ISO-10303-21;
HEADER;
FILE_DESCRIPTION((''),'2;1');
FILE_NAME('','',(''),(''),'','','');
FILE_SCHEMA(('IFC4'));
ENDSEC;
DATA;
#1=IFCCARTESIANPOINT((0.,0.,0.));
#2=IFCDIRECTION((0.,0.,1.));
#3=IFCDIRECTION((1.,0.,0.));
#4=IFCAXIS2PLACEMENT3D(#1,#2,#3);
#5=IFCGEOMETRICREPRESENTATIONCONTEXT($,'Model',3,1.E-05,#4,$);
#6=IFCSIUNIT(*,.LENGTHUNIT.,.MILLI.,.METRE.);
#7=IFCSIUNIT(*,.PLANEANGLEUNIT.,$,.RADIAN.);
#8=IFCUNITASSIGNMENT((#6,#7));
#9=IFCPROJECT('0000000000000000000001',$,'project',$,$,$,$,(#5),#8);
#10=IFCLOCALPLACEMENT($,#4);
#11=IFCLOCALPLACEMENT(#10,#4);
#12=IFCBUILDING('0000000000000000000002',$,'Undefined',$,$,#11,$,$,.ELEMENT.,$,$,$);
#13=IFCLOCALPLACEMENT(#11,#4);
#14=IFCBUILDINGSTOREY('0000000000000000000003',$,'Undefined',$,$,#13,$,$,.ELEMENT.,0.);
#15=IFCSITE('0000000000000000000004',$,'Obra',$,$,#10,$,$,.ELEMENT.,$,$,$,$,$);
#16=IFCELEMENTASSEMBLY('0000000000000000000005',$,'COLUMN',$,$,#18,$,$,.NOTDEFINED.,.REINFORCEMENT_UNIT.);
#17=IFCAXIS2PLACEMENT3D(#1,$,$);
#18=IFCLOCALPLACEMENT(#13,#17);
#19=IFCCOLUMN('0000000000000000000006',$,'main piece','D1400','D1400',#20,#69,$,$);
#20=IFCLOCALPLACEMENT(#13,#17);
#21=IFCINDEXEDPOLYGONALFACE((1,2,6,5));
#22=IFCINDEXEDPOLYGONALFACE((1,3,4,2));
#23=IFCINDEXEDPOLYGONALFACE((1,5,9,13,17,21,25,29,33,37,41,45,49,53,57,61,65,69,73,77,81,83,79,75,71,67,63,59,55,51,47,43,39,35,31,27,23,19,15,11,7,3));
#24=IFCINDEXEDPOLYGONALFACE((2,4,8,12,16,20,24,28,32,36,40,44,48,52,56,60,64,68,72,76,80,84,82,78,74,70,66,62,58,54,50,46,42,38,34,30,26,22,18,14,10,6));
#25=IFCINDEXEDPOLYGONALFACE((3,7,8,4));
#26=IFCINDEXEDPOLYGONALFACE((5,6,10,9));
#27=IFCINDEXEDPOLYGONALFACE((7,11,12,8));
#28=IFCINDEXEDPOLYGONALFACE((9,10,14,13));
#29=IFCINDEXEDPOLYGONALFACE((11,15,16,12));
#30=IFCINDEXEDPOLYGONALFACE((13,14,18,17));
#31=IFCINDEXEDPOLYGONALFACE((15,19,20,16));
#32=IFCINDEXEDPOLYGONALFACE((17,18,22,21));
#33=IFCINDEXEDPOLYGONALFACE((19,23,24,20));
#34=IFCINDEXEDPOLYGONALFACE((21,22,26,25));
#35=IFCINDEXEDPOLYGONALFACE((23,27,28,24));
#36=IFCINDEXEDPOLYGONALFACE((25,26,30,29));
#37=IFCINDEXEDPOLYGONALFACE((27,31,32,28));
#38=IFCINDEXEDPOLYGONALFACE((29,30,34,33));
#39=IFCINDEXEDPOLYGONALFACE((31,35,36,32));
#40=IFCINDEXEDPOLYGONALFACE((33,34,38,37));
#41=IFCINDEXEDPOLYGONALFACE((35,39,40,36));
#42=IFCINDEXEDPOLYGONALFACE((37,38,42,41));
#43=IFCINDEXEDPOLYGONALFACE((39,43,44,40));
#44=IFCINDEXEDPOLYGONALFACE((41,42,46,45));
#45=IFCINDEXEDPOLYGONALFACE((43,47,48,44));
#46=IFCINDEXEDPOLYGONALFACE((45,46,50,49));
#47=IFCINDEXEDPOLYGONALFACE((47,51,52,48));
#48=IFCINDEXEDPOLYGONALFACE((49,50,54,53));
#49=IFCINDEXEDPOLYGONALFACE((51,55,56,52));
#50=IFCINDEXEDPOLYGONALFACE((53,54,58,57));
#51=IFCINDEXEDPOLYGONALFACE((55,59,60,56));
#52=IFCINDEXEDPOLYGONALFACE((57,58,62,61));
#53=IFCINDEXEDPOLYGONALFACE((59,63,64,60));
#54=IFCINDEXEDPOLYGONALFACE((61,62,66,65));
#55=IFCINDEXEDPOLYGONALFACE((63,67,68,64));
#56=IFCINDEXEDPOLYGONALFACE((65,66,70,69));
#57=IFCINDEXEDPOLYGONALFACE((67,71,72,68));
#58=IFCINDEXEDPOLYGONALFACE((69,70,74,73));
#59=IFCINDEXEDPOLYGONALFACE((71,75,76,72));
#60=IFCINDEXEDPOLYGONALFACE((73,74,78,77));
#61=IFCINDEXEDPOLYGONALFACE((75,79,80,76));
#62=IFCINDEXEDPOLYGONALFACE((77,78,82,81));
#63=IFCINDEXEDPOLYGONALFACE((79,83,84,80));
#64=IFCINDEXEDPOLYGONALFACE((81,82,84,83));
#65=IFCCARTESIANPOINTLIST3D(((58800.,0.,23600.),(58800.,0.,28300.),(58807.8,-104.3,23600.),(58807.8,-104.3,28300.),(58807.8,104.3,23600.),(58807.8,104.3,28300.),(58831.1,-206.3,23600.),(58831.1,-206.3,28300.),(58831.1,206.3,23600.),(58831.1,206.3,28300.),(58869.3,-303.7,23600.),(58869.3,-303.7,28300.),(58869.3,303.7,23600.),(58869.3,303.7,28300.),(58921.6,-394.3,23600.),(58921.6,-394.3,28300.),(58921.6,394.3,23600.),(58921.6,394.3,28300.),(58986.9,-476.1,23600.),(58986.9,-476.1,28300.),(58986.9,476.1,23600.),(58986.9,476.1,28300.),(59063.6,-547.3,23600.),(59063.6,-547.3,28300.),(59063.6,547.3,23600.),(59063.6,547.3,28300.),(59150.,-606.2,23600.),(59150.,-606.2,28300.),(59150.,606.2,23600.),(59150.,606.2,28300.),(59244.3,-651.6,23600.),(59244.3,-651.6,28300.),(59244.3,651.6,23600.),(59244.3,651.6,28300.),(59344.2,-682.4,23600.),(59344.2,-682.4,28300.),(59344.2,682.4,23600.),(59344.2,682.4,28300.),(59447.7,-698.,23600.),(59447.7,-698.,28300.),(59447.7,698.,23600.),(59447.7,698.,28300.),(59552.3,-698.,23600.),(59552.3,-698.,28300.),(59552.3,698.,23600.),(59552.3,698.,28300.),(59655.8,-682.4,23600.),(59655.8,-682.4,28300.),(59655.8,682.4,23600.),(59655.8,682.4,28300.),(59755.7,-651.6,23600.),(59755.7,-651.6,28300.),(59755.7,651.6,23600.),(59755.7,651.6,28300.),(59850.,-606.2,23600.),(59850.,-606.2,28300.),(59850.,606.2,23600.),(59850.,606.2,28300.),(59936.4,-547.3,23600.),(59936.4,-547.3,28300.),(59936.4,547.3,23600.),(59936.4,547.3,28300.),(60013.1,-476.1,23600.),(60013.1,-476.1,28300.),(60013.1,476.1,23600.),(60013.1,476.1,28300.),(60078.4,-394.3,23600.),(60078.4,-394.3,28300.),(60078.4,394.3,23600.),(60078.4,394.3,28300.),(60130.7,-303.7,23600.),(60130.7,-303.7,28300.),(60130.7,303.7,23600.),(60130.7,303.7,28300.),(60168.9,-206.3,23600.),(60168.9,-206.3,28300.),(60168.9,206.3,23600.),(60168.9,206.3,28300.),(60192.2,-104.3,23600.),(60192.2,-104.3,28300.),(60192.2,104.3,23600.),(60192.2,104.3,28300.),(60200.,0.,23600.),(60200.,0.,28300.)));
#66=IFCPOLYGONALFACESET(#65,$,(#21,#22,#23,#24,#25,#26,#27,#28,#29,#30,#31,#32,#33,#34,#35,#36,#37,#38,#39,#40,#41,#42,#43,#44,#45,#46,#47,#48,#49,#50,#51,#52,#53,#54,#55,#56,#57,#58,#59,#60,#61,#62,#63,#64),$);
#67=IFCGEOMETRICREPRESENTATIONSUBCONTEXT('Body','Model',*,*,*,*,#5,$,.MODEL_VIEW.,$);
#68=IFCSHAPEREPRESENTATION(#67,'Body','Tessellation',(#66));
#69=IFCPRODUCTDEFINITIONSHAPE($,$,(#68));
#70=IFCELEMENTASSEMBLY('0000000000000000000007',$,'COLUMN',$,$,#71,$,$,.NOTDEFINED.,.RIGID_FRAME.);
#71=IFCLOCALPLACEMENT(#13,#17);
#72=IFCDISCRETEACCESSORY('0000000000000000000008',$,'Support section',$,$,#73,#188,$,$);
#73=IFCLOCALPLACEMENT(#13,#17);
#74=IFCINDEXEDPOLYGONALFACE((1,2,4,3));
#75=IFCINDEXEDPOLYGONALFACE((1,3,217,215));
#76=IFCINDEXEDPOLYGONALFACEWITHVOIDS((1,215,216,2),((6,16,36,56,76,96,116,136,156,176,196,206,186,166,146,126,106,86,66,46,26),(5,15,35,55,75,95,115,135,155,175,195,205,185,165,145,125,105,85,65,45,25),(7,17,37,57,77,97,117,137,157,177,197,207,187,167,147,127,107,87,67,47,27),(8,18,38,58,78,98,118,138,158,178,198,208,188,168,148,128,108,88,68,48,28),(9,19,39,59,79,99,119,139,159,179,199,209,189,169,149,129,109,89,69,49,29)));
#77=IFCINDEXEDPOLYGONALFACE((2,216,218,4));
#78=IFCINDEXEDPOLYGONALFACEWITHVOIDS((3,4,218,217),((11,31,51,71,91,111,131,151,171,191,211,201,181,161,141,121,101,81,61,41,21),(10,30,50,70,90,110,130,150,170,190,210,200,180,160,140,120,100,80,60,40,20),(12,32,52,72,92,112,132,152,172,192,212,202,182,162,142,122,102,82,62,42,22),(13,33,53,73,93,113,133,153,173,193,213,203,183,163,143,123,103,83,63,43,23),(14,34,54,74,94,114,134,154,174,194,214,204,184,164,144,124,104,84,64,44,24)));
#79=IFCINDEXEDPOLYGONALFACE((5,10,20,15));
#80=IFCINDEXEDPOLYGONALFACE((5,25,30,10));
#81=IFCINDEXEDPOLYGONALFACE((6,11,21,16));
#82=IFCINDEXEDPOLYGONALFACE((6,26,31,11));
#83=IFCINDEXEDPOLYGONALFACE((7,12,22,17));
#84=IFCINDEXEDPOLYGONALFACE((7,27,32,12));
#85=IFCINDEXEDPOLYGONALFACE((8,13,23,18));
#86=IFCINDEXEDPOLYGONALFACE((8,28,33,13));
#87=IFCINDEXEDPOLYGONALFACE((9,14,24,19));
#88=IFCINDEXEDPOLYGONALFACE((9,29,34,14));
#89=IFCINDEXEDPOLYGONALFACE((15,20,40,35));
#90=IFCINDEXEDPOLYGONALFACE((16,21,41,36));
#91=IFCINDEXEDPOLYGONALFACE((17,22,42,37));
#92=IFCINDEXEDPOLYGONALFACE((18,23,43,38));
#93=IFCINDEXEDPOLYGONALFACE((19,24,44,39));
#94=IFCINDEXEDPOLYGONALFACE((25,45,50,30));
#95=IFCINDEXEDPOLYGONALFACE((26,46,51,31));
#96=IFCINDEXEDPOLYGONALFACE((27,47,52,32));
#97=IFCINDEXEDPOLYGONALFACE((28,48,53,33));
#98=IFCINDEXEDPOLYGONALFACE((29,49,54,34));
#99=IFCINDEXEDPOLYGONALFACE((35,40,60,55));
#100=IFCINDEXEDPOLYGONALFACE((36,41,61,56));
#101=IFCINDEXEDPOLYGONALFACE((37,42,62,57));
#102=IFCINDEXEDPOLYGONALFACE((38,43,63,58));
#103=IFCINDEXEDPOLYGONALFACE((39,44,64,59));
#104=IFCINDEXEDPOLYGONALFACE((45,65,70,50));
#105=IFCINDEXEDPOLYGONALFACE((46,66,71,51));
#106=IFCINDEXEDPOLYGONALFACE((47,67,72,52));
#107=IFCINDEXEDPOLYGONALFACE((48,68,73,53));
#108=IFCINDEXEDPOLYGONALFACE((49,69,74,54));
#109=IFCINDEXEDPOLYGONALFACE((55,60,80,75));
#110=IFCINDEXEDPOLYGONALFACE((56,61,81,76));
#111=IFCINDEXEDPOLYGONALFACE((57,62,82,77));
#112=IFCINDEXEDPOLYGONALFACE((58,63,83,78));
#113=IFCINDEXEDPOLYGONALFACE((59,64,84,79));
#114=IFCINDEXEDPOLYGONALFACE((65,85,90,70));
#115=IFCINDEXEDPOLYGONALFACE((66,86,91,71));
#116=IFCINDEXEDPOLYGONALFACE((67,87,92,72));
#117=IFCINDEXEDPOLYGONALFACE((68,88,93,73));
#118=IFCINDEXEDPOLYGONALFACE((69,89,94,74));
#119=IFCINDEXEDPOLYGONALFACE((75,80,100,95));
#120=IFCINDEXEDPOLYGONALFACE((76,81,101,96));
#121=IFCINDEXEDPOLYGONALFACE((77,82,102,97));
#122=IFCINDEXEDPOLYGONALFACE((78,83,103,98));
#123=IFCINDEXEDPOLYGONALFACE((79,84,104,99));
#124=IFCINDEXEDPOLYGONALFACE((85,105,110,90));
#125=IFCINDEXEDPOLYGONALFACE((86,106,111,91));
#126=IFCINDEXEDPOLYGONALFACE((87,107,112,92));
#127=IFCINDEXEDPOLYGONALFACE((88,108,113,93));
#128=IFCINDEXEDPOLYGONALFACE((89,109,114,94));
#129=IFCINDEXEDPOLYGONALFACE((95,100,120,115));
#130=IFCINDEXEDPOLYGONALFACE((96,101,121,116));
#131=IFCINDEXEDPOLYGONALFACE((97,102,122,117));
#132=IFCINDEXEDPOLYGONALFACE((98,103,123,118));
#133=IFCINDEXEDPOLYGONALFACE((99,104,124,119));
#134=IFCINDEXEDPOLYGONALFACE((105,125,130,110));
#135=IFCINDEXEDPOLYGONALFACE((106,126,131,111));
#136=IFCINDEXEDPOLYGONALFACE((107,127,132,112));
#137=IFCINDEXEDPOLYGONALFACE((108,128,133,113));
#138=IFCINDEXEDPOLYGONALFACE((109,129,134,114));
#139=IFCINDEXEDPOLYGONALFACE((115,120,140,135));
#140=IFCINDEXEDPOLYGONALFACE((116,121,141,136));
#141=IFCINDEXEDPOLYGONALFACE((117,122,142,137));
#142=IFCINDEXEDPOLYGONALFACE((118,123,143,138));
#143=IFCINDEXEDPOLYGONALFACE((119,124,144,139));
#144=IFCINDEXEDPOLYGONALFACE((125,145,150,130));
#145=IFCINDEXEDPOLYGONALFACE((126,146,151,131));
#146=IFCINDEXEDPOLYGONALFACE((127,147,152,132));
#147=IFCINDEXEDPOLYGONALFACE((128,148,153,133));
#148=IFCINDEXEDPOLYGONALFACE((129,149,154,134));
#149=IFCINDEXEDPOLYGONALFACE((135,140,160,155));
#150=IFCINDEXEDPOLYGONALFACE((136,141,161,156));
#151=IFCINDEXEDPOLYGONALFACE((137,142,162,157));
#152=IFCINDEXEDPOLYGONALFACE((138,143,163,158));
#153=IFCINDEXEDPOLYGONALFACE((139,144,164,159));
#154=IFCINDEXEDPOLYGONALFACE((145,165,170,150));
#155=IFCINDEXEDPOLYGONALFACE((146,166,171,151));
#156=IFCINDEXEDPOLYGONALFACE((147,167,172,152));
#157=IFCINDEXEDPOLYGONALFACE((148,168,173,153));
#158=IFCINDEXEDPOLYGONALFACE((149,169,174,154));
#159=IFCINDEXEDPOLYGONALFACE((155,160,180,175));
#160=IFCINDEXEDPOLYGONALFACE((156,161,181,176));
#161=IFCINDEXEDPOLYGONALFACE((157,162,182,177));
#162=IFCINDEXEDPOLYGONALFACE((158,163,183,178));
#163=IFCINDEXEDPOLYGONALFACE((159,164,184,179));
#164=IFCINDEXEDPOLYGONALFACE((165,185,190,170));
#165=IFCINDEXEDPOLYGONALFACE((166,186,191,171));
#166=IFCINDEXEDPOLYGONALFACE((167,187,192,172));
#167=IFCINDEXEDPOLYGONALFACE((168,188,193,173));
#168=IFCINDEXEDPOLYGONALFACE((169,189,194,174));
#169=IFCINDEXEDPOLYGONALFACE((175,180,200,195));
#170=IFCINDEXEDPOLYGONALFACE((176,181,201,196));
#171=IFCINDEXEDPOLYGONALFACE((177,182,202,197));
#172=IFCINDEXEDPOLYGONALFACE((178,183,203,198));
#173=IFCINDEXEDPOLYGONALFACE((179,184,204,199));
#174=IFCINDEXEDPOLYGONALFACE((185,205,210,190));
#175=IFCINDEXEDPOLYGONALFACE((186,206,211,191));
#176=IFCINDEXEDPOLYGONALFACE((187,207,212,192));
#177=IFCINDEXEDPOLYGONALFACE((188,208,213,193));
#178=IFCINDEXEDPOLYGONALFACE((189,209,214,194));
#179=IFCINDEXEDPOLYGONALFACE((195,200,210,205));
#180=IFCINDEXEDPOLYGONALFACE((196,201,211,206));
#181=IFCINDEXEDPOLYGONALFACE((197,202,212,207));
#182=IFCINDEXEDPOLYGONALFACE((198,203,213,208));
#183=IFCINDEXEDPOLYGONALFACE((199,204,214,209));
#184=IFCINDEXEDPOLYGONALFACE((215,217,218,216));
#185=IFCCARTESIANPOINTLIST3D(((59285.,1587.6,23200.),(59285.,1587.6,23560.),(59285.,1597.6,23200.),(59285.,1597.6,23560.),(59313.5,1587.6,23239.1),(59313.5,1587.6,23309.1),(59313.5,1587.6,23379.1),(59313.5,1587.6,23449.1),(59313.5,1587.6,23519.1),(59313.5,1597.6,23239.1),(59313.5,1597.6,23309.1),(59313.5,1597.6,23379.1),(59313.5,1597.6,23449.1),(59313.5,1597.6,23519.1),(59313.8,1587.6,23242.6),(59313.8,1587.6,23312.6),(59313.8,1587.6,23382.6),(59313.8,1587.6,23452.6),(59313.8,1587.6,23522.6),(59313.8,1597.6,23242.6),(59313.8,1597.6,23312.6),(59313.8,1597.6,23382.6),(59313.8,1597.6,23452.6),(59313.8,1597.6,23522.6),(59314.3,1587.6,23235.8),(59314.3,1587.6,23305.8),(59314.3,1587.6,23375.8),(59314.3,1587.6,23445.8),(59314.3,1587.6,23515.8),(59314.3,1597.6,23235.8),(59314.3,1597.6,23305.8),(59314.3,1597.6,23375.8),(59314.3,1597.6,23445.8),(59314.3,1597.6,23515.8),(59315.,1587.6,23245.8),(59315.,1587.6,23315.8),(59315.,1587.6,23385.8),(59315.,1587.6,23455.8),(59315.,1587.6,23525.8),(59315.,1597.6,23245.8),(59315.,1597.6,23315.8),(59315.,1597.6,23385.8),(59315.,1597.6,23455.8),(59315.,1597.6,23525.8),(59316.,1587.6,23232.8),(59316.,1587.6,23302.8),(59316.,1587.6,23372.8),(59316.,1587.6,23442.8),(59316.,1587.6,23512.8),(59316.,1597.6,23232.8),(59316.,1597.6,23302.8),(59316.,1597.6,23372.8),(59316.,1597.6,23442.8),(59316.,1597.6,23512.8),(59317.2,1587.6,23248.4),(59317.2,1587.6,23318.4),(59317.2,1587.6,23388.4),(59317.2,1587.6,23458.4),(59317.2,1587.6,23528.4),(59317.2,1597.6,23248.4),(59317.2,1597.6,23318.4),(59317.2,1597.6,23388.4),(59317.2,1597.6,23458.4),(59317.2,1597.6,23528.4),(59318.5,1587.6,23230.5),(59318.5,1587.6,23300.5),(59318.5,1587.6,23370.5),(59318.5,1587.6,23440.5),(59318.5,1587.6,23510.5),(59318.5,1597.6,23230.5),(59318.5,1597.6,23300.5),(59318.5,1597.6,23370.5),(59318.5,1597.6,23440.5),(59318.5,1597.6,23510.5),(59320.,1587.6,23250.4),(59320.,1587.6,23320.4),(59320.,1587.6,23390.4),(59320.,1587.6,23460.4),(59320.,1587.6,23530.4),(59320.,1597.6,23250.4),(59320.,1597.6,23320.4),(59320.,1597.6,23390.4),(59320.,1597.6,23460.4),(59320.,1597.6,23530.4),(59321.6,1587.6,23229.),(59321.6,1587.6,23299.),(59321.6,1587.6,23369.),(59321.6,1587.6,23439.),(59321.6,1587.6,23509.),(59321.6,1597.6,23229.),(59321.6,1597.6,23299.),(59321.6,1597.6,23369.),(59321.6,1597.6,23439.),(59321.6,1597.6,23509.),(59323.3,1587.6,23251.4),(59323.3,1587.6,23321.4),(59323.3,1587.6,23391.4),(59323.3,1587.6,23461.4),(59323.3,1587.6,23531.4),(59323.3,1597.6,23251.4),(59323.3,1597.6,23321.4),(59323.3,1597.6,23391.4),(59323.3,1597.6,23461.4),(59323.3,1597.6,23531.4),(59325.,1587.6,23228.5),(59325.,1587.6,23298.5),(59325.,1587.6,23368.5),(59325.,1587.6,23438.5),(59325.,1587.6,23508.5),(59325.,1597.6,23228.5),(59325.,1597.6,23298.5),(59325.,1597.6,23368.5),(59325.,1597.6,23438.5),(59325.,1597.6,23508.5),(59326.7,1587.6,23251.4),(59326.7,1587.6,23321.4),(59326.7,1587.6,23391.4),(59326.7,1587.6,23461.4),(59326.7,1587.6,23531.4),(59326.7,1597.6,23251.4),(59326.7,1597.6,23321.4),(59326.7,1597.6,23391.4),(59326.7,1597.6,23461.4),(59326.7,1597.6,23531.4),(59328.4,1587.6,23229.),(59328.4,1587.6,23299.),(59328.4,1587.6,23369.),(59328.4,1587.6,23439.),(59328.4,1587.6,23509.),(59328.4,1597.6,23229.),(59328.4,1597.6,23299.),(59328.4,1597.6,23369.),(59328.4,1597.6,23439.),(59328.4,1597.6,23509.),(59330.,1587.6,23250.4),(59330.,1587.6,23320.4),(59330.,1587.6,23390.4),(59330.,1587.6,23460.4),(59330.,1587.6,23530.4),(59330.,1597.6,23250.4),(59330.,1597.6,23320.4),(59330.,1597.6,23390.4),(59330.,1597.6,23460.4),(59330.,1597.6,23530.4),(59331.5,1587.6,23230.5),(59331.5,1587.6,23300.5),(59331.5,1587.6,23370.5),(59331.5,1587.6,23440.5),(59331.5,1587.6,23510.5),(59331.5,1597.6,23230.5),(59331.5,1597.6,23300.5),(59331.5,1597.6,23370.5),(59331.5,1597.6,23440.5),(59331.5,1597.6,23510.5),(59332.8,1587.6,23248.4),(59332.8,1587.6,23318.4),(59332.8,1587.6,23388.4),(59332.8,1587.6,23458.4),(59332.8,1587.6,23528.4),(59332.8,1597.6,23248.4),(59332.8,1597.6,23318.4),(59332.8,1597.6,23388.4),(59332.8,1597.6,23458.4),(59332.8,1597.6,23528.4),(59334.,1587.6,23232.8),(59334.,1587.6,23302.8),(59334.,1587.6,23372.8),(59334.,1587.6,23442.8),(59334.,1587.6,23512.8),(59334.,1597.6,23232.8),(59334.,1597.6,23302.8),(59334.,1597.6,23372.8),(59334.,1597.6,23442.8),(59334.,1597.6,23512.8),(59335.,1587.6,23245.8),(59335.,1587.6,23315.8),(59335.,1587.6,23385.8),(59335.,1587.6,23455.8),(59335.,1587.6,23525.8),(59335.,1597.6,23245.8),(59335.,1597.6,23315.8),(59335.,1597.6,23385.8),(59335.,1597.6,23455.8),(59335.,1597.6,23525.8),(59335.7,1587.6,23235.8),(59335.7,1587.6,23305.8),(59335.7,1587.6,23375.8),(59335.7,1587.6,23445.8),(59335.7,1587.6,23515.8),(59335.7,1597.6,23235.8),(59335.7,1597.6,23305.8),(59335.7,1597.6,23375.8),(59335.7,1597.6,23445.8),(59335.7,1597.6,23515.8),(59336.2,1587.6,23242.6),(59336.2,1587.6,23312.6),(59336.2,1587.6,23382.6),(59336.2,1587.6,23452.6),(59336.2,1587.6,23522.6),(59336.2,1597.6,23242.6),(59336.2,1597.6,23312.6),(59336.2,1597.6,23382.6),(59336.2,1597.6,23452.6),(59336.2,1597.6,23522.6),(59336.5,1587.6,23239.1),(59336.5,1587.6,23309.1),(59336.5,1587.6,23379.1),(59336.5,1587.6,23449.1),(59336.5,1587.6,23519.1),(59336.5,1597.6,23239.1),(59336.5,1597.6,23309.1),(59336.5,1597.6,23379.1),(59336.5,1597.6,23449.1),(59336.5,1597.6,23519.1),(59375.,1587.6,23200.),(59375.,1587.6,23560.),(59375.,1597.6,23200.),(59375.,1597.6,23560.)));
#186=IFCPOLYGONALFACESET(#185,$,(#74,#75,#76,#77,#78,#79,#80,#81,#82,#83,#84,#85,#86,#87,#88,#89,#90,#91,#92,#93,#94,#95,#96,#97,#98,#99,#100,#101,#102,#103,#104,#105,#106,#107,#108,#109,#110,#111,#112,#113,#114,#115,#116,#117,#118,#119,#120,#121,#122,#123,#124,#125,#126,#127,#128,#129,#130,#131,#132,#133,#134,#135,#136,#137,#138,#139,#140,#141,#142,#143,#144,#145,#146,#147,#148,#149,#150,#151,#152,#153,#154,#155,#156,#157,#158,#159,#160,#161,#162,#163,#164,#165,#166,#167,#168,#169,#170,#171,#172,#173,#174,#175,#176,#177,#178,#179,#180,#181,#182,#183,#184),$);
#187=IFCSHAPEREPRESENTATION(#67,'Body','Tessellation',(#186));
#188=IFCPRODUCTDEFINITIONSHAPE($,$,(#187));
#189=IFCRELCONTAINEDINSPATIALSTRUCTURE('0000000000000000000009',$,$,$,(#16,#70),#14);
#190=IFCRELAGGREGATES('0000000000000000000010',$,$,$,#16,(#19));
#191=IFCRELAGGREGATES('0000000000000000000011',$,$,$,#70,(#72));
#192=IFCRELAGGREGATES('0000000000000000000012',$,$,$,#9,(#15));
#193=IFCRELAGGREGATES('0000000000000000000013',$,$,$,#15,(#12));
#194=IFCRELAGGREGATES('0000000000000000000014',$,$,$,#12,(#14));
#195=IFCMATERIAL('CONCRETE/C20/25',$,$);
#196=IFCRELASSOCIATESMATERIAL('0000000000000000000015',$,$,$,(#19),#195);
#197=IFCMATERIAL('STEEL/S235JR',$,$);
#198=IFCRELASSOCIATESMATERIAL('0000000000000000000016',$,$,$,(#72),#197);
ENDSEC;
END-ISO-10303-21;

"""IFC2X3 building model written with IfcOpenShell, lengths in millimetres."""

from ifc_helpers import new_model, si_unit, frame, origin_with_axes, origin_2d_with_axis, place, context, subcontext, project, spatial, rectangle, circle, extrude, source, transform, mapped, material, element, aggregate, save


model = new_model("IFC2X3")

# Units and contexts
model_context = context("Model", 3, precision=1e-05, world=origin_with_axes())
body_context = subcontext(model_context, "Body", "Model", "MODEL_VIEW")
ifc_project = project(units=[si_unit("LENGTHUNIT", "METRE", prefix="MILLI"), si_unit("PLANEANGLEUNIT", "RADIAN")], contexts=[model_context])

# Site, building, storey
site_placement = place(None, origin_with_axes())
site = spatial("IfcSite", under=ifc_project, at=site_placement, Name="Obra", CompositionType="ELEMENT")
building_placement = place(site_placement, origin_with_axes())
building = spatial("IfcBuilding", under=site, at=building_placement, Name="Undefined", CompositionType="ELEMENT")
storey_placement = place(building_placement, origin_with_axes())
storey = spatial("IfcBuildingStorey", under=building, at=storey_placement, Name="Undefined", CompositionType="ELEMENT", Elevation=0.0)

# Element assembly, column
assembly_1_placement = place(storey_placement, origin_with_axes())
assembly_1 = element("IfcElementAssembly", 1, at=assembly_1_placement, inside=storey, Name="COLUMN", AssemblyPlace="NOTDEFINED", PredefinedType="REINFORCEMENT_UNIT")
ifc_material_1 = material(Name="CONCRETE/C20/25")
column_placement = place(assembly_1_placement, frame((59500.0, 0.0, 23600.0), z_axis=(0.0, 0.0, 1.0), x_axis=(0.0, 1.0, 0.0)))
column = element("IfcColumn", 2, at=column_placement, material=ifc_material_1, Name="main piece", Description="D1400", ObjectType="D1400", context=body_context, shape_type="SweptSolid", body=[
    extrude(circle(Radius=700.0, at=origin_2d_with_axis()), frame((0.0, 0.0, 4700.0), z_axis=(0.0, 0.0, -1.0), x_axis=(0.0, 1.0, 0.0)), (0.0, 0.0, 1.0), 4700.0),
])
aggregate(assembly_1, [column])

# Shared definitions
ifc_material_2 = material(Name="STEEL/S235JR")

# Element assembly, discrete accessory, opening
assembly_2_placement = place(storey_placement, origin_with_axes())
assembly_2 = element("IfcElementAssembly", 3, at=assembly_2_placement, inside=storey, Name="COLUMN", AssemblyPlace="NOTDEFINED", PredefinedType="RIGID_FRAME")
discrete_accessory_1_placement = place(assembly_2_placement, frame((59330.0, 1592.6, 23200.0), z_axis=(0.0, 0.0, 1.0), x_axis=(1.0, 0.0, 0.0)))
discrete_accessory_1 = element("IfcDiscreteAccessory", 4, at=discrete_accessory_1_placement, material=ifc_material_2, Name="Support section", context=body_context, shape_type="SweptSolid", body=[
    extrude(rectangle(XDim=10.0, YDim=90.0, at=origin_2d_with_axis()), frame((0.0, 0.0, 360.0), z_axis=(0.0, 0.0, -1.0), x_axis=(0.0, 1.0, 0.0)), (0.0, 0.0, 1.0), 360.0),
])
shared_shape_1 = source(origin_with_axes(), body_context, "Body", "SweptSolid", [
    extrude(circle(Radius=11.5, at=origin_2d_with_axis()), frame((0.0, 5.7, 0.0), z_axis=(0.0, 1.0, 0.0), x_axis=(1.0, 0.0, 0.0)), (0.0, 0.0, 1.0), 10.2),
])
opening_1_placement = place(assembly_2_placement, frame((59365.0, 1603.4, 23600.0), z_axis=(-1.0, 0.0, 0.0), x_axis=(0.0, 0.0, -1.0)))
element("IfcOpeningElement", 5, at=opening_1_placement, cuts=discrete_accessory_1, ObjectType="Opening", context=body_context, shape_type="MappedRepresentation", body=[
    mapped(shared_shape_1, transform((80.0, 0.0, 40.0))),
    mapped(shared_shape_1, transform((150.0, 0.0, 40.0))),
    mapped(shared_shape_1, transform((220.0, 0.0, 40.0))),
    mapped(shared_shape_1, transform((290.0, 0.0, 40.0))),
    mapped(shared_shape_1, transform((360.0, 0.0, 40.0))),
])
aggregate(assembly_2, [discrete_accessory_1])

save(model, "model.ifc")
